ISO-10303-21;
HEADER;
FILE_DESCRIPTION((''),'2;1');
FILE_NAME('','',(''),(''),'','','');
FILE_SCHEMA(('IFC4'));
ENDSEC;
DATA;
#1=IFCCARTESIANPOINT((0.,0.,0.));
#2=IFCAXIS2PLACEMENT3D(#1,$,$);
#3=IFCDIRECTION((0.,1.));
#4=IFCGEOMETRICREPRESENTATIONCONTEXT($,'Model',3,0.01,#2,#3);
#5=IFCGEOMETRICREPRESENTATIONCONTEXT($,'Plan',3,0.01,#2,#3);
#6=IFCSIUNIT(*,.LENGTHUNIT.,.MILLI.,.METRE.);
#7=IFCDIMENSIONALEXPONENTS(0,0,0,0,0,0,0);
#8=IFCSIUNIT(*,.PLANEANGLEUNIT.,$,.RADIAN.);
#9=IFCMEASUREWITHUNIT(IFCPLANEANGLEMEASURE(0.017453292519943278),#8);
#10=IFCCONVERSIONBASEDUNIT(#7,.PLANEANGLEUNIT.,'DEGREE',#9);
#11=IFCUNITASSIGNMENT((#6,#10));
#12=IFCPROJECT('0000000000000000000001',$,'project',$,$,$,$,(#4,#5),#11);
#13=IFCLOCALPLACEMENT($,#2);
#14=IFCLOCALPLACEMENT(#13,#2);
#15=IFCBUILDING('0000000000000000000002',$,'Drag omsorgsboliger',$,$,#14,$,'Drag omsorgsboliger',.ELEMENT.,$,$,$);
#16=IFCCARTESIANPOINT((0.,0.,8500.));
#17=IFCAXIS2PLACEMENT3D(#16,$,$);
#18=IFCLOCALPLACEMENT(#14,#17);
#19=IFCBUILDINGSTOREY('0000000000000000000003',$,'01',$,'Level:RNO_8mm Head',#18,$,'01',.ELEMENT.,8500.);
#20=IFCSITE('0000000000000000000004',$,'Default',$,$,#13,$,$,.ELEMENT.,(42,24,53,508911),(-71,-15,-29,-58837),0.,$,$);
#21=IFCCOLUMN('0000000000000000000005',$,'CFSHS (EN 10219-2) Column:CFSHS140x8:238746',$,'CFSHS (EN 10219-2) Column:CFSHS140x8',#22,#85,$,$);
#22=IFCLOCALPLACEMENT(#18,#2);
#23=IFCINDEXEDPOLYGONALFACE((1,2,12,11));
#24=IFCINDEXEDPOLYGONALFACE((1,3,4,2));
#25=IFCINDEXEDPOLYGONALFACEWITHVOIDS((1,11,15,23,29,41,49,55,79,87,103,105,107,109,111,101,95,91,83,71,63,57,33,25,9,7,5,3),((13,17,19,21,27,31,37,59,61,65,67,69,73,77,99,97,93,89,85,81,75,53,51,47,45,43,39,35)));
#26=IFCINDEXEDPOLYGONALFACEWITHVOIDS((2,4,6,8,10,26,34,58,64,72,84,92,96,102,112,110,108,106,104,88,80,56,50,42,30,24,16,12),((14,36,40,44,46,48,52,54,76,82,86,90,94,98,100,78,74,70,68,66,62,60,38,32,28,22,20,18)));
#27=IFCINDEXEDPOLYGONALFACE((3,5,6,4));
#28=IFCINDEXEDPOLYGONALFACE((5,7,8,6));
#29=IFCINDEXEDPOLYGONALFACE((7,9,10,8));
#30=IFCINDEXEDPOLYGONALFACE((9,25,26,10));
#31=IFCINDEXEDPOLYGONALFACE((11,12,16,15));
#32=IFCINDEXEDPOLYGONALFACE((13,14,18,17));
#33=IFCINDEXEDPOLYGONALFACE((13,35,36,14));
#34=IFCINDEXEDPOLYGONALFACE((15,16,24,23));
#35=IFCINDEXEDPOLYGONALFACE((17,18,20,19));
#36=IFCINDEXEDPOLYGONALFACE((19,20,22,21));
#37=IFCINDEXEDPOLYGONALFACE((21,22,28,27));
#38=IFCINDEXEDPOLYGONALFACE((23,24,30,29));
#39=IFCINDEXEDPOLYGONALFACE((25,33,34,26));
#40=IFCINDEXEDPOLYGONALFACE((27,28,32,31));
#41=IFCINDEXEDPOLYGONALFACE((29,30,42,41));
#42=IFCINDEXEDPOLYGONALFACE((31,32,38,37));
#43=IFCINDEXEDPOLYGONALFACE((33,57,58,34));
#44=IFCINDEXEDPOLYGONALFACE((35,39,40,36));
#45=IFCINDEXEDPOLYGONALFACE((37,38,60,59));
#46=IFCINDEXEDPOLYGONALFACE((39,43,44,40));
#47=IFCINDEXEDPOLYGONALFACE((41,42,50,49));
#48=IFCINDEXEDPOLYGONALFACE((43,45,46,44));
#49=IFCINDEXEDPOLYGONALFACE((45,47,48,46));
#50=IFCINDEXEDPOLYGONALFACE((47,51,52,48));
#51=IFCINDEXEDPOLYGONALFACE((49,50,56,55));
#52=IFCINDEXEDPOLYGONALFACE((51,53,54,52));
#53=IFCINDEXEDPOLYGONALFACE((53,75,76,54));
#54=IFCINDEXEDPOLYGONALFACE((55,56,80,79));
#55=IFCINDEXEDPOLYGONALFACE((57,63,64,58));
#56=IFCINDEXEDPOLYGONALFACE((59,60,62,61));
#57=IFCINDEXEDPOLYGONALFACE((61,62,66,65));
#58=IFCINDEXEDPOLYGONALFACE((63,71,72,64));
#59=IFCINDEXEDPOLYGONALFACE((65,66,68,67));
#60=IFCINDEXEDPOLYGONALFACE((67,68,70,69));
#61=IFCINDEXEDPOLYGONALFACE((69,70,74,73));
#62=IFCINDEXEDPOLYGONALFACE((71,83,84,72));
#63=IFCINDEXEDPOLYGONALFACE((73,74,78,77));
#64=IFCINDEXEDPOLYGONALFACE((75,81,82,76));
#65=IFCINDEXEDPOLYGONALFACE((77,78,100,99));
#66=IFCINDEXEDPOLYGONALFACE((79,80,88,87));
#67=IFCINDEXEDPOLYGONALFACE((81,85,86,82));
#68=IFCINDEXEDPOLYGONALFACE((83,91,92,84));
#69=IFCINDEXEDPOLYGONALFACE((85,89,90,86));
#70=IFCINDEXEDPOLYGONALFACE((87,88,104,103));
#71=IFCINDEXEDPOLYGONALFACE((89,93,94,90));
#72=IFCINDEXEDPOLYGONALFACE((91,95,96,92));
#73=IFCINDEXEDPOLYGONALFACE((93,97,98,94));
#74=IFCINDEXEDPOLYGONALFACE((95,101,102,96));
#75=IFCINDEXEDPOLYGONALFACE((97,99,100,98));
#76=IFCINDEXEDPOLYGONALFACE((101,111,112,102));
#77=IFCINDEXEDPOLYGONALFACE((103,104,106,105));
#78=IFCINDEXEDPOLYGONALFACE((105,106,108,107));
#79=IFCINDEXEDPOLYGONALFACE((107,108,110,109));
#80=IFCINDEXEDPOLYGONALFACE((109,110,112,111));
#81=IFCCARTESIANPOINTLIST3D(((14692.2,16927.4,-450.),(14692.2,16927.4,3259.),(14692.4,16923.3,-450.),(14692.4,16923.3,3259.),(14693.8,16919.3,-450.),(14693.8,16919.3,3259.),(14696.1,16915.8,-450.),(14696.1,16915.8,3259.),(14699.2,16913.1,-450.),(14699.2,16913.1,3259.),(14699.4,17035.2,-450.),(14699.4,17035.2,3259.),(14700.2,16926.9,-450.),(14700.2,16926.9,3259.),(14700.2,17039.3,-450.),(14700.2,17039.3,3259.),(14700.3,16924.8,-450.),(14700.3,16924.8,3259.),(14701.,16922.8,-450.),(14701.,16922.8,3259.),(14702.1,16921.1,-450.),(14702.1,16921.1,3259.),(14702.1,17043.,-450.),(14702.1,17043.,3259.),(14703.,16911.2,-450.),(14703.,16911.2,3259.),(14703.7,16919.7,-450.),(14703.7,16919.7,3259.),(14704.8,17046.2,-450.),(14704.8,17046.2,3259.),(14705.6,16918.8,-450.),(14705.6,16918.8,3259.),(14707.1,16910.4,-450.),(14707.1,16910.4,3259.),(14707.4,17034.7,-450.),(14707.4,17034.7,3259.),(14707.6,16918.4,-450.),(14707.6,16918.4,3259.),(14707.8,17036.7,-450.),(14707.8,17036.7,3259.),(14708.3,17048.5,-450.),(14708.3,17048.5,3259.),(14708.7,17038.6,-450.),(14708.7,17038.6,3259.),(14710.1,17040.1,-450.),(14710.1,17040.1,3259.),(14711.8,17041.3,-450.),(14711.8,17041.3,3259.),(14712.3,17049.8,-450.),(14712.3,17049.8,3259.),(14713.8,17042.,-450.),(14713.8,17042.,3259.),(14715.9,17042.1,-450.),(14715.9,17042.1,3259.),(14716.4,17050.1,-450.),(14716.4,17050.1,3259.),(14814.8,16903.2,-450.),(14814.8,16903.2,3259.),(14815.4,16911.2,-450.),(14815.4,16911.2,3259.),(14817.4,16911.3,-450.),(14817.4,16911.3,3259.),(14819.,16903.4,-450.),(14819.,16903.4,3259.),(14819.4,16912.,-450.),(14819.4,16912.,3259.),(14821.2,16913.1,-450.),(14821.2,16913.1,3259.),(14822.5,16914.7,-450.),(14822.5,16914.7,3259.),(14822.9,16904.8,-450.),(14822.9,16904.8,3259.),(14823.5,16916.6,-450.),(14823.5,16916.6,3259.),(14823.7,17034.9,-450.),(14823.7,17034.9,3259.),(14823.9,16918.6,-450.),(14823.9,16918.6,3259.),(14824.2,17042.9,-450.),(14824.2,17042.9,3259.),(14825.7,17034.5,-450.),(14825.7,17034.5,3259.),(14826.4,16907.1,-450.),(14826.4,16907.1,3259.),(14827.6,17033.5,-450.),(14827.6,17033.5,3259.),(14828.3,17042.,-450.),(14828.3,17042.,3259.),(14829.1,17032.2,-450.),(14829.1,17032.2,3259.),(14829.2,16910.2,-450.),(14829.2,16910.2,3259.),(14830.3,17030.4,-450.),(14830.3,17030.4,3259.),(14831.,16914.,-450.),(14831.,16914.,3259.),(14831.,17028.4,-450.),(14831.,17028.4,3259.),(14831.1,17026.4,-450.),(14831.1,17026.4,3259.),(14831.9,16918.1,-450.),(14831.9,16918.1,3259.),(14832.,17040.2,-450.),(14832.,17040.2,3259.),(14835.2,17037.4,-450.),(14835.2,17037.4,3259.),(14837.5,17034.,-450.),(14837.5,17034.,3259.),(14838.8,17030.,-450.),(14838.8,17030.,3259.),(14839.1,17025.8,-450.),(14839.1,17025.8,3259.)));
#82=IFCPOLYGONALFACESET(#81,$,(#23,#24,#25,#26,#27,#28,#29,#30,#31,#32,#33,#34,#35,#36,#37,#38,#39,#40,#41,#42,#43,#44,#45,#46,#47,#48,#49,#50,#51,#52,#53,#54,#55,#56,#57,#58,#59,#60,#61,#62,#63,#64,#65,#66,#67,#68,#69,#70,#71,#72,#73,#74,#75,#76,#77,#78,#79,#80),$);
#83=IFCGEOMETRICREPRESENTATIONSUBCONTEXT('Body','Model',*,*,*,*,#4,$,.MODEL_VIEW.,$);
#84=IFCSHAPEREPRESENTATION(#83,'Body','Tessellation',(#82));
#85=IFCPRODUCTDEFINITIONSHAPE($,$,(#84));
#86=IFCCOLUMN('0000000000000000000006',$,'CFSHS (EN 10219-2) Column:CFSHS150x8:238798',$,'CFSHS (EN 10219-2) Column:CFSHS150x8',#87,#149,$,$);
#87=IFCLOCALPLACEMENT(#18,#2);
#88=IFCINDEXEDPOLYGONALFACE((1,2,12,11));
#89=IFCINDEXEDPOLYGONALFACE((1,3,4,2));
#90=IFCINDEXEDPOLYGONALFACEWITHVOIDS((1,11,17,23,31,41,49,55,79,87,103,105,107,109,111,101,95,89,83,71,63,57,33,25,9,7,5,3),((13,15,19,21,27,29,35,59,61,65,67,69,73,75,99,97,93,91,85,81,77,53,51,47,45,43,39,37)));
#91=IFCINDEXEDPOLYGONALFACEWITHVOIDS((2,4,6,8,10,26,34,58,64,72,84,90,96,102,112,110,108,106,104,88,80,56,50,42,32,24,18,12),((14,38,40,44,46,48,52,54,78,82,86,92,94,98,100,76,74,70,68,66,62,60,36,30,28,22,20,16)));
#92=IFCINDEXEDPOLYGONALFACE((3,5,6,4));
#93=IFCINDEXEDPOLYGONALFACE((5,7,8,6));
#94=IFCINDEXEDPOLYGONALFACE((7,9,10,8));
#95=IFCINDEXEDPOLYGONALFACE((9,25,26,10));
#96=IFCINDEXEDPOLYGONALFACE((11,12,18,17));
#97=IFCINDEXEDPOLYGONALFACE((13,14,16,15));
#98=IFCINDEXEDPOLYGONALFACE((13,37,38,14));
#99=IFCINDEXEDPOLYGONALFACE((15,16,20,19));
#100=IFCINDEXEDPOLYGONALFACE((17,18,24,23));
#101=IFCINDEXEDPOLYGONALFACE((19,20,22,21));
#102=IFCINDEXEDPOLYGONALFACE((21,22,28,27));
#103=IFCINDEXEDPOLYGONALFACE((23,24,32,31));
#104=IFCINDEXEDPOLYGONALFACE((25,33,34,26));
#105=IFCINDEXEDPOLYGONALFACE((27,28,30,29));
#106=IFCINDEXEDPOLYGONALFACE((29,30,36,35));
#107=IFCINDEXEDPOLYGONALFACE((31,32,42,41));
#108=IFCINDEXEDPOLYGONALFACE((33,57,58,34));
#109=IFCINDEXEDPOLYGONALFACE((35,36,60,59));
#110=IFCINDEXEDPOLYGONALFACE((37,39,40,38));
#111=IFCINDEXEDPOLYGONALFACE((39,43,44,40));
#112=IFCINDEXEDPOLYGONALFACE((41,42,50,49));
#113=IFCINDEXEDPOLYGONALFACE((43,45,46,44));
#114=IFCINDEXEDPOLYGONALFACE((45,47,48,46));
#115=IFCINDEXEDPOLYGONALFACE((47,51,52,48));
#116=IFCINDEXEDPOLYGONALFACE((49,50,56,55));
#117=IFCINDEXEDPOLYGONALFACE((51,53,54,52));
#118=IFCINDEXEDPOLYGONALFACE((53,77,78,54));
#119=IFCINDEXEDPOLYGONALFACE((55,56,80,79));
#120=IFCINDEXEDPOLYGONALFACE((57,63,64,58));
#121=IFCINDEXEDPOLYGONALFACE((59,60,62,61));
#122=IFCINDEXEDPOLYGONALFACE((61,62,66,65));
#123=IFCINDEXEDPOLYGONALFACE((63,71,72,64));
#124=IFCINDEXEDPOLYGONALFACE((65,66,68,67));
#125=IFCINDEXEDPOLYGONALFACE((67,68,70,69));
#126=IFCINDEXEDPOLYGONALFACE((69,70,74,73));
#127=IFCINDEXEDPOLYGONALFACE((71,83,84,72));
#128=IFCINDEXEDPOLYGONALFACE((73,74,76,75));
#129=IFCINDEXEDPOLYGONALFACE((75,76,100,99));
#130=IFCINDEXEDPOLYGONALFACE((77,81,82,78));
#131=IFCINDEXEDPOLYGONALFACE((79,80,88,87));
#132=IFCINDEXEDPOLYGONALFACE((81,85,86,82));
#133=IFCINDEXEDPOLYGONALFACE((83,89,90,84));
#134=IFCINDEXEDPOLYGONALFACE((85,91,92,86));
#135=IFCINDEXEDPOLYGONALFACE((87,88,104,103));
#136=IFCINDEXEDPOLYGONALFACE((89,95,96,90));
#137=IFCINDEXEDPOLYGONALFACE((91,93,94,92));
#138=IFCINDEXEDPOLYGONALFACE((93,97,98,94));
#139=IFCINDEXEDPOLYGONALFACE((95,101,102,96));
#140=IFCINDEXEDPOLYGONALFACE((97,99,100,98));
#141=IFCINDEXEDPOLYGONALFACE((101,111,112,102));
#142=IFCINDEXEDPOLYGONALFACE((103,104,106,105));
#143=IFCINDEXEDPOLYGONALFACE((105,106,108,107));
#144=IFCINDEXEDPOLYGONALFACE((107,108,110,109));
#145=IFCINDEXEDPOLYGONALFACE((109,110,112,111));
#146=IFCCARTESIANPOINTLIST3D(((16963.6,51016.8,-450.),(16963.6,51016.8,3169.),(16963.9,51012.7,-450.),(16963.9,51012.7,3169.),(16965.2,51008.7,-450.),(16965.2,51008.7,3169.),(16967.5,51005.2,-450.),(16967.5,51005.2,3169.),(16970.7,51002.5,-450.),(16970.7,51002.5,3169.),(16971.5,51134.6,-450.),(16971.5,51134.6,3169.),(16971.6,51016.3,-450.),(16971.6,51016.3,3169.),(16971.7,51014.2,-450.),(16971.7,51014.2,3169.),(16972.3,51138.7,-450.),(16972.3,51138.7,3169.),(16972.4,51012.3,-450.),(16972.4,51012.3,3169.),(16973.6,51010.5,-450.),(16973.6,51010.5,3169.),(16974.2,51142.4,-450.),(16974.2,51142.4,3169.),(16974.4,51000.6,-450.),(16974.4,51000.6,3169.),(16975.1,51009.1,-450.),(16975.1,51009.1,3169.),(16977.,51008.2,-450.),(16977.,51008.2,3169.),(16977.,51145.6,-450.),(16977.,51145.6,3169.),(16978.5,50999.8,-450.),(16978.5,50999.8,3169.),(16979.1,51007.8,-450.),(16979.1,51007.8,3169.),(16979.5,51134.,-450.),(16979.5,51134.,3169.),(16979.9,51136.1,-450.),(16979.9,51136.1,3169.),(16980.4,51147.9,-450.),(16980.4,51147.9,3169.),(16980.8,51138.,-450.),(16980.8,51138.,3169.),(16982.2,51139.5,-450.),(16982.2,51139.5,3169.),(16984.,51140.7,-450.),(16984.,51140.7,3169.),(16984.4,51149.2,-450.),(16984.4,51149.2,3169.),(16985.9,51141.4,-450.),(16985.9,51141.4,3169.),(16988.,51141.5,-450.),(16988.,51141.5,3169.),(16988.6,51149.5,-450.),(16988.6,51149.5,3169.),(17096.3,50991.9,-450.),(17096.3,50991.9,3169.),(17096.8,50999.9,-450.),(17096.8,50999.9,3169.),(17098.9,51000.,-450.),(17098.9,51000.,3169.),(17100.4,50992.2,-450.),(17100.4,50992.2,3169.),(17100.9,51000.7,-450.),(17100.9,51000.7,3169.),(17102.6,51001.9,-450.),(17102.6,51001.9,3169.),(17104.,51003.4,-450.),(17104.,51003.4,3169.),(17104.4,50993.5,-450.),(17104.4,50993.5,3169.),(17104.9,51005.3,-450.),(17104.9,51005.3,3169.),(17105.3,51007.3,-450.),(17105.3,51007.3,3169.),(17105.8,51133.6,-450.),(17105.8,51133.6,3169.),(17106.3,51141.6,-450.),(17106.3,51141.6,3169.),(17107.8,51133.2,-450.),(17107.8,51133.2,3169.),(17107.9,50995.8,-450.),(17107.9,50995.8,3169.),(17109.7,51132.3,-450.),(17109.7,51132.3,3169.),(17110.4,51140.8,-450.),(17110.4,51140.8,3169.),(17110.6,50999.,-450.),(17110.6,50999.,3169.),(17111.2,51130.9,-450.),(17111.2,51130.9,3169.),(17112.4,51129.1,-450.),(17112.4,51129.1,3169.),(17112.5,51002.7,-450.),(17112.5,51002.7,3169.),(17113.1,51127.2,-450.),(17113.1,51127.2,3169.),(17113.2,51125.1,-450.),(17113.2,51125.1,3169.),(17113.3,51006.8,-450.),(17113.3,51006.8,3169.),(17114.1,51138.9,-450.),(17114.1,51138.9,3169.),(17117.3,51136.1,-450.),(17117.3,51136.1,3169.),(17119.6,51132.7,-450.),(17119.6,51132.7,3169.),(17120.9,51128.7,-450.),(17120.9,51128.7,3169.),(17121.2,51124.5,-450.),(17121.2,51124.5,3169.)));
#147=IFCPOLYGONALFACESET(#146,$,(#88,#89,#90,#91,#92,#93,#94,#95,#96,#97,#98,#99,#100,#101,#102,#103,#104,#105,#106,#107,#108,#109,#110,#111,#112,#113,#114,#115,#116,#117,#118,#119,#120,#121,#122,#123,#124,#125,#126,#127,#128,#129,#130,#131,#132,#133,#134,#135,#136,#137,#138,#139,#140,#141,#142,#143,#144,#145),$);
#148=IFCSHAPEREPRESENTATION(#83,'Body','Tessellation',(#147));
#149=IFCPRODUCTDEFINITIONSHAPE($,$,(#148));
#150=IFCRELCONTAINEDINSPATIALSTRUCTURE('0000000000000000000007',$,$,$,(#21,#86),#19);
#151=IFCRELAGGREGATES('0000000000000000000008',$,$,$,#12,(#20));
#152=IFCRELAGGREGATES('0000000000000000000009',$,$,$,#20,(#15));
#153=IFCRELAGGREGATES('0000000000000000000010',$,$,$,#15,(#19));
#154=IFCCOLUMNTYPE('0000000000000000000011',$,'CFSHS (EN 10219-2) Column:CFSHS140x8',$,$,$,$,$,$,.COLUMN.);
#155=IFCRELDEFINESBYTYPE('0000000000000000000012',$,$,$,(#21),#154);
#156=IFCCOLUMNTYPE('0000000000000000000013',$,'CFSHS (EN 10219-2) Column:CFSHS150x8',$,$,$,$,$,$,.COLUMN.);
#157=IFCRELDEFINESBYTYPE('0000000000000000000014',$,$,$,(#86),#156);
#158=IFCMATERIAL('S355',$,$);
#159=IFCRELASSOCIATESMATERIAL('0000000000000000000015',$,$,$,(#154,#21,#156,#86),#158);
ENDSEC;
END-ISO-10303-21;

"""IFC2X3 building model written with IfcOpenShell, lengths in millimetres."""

from ifc_helpers import new_model, entity, si_unit, converted_unit, direction, frame, frame_2d, origin, place, context, subcontext, project, spatial, polyline, circle_curve, parameter, trimmed, segment, composite_curve, outline, extrude, source, transform, mapped, material, type_object, type_shapes, element, save


model = new_model("IFC2X3")

# Units and contexts
model_context = context("Model", 3, precision=0.01, world=origin(), true_north=direction((0.0, 1.0)))
plan_context = context("Plan", 3, precision=0.01, world=origin(), true_north=direction((0.0, 1.0)))
body_context = subcontext(model_context, "Body", "Model", "MODEL_VIEW")
ifc_project = project(units=[si_unit("LENGTHUNIT", "METRE", prefix="MILLI"), converted_unit("PLANEANGLEUNIT", "DEGREE", entity("IfcPlaneAngleMeasure", 0.017453292519943278), si_unit("PLANEANGLEUNIT", "RADIAN"), dimensions=[0, 0, 0, 0, 0, 0, 0])], contexts=[model_context, plan_context])

# Site, building, storey
site_placement = place(None, origin())
site = spatial("IfcSite", under=ifc_project, at=site_placement, Name="Default", CompositionType="ELEMENT", RefLatitude=(42, 24, 53, 508911), RefLongitude=(-71, -15, -29, -58837), RefElevation=0.0)
building_placement = place(site_placement, origin())
building = spatial("IfcBuilding", under=site, at=building_placement, Name="Drag omsorgsboliger", LongName="Drag omsorgsboliger", CompositionType="ELEMENT")
storey_placement = place(building_placement, frame((0.0, 0.0, 8500.0)))
storey = spatial("IfcBuildingStorey", under=building, at=storey_placement, Name="01", ObjectType="Level:RNO_8mm Head", LongName="01", CompositionType="ELEMENT", Elevation=8500.0)

# Columns
ifc_material = material(Name="S355")
column_type_1 = type_object("IfcColumnType", Name="CFSHS (EN 10219-2) Column:CFSHS140x8", PredefinedType="COLUMN", material=ifc_material)
shared_shape_1 = source(origin(), body_context, "Body", "SweptSolid", [
    extrude(outline(composite_curve([segment(polyline([(-54.0, -70.0), (54.0, -70.0)]), True, "CONTINUOUS"), segment(trimmed(circle_curve(frame_2d((54.0, -54.0), x_axis=(-1.0, 0.0)), 16.0), [parameter(90.0)], [parameter(180.0)], True, "PARAMETER"), True, "CONTINUOUS"), segment(polyline([(70.0, -54.0), (70.0, 54.0)]), True, "CONTINUOUS"), segment(trimmed(circle_curve(frame_2d((54.0, 54.0), x_axis=(-1.0, 0.0)), 16.0), [parameter(180.0)], [parameter(270.0)], True, "PARAMETER"), True, "CONTINUOUS"), segment(polyline([(54.0, 70.0), (-54.0, 70.0)]), True, "CONTINUOUS"), segment(trimmed(circle_curve(frame_2d((-54.0, 54.0), x_axis=(-1.0, 0.0)), 16.0), [parameter(270.0)], [parameter(360.0)], True, "PARAMETER"), True, "CONTINUOUS"), segment(polyline([(-70.0, 54.0), (-70.0, -54.0)]), True, "CONTINUOUS"), segment(trimmed(circle_curve(frame_2d((-54.0, -54.0), x_axis=(-1.0, 0.0)), 16.0), [parameter(360.0)], [parameter(90.0)], True, "PARAMETER"), True, "CONTINUOUS")], self_intersect=False), holes=[composite_curve([segment(trimmed(circle_curve(frame_2d((-54.0, -54.0), x_axis=(-1.0, 0.0)), 8.0), [parameter(360.0)], [parameter(90.0)], True, "PARAMETER"), False, "CONTINUOUS"), segment(polyline([(-62.0, -54.0), (-62.0, 54.0)]), True, "CONTINUOUS"), segment(trimmed(circle_curve(frame_2d((-54.0, 54.0), x_axis=(-1.0, 0.0)), 8.0), [parameter(270.0)], [parameter(360.0)], True, "PARAMETER"), False, "CONTINUOUS"), segment(polyline([(-54.0, 62.0), (54.0, 62.0)]), True, "CONTINUOUS"), segment(trimmed(circle_curve(frame_2d((54.0, 54.0), x_axis=(-1.0, 0.0)), 8.0), [parameter(180.0)], [parameter(270.0)], True, "PARAMETER"), False, "CONTINUOUS"), segment(polyline([(62.0, 54.0), (62.0, -54.0)]), True, "CONTINUOUS"), segment(trimmed(circle_curve(frame_2d((54.0, -54.0), x_axis=(-1.0, 0.0)), 8.0), [parameter(90.0)], [parameter(180.0)], True, "PARAMETER"), False, "CONTINUOUS"), segment(polyline([(54.0, -62.0), (-54.0, -62.0)]), True, "CONTINUOUS")], self_intersect=False)]), frame((14765.6, 16976.6, 8050.0), z_axis=(0.0, 0.0, 1.0), x_axis=(-0.997758, 0.066923, 0.0)), (0.0, 0.0, 1.0), 3709.0),
])
type_shapes(column_type_1, [shared_shape_1])
column_1_placement = place(storey_placement, frame((0.0, 0.0, -8500.0)))
element("IfcColumn", 1, at=column_1_placement, inside=storey, type_object=column_type_1, material=ifc_material, Name="CFSHS (EN 10219-2) Column:CFSHS140x8:238746", ObjectType="CFSHS (EN 10219-2) Column:CFSHS140x8", context=body_context, shape_type="MappedRepresentation", body=[
    mapped(shared_shape_1, transform((0.0, 0.0, 0.0), scale=1.0)),
])
column_type_2 = type_object("IfcColumnType", Name="CFSHS (EN 10219-2) Column:CFSHS150x8", PredefinedType="COLUMN", material=ifc_material)
shared_shape_2 = source(origin(), body_context, "Body", "SweptSolid", [
    extrude(outline(composite_curve([segment(polyline([(-59.0, -75.0), (59.0, -75.0)]), True, "CONTINUOUS"), segment(trimmed(circle_curve(frame_2d((59.0, -59.0), x_axis=(-1.0, 0.0)), 16.0), [parameter(90.0)], [parameter(180.0)], True, "PARAMETER"), True, "CONTINUOUS"), segment(polyline([(75.0, -59.0), (75.0, 59.0)]), True, "CONTINUOUS"), segment(trimmed(circle_curve(frame_2d((59.0, 59.0), x_axis=(-1.0, 0.0)), 16.0), [parameter(180.0)], [parameter(270.0)], True, "PARAMETER"), True, "CONTINUOUS"), segment(polyline([(59.0, 75.0), (-59.0, 75.0)]), True, "CONTINUOUS"), segment(trimmed(circle_curve(frame_2d((-59.0, 59.0), x_axis=(-1.0, 0.0)), 16.0), [parameter(270.0)], [parameter(360.0)], True, "PARAMETER"), True, "CONTINUOUS"), segment(polyline([(-75.0, 59.0), (-75.0, -59.0)]), True, "CONTINUOUS"), segment(trimmed(circle_curve(frame_2d((-59.0, -59.0), x_axis=(-1.0, 0.0)), 16.0), [parameter(360.0)], [parameter(90.0)], True, "PARAMETER"), True, "CONTINUOUS")], self_intersect=False), holes=[composite_curve([segment(trimmed(circle_curve(frame_2d((-59.0, -59.0), x_axis=(-1.0, 0.0)), 8.0), [parameter(360.0)], [parameter(90.0)], True, "PARAMETER"), False, "CONTINUOUS"), segment(polyline([(-67.0, -59.0), (-67.0, 59.0)]), True, "CONTINUOUS"), segment(trimmed(circle_curve(frame_2d((-59.0, 59.0), x_axis=(-1.0, 0.0)), 8.0), [parameter(270.0)], [parameter(360.0)], True, "PARAMETER"), False, "CONTINUOUS"), segment(polyline([(-59.0, 67.0), (59.0, 67.0)]), True, "CONTINUOUS"), segment(trimmed(circle_curve(frame_2d((59.0, 59.0), x_axis=(-1.0, 0.0)), 8.0), [parameter(180.0)], [parameter(270.0)], True, "PARAMETER"), False, "CONTINUOUS"), segment(polyline([(67.0, 59.0), (67.0, -59.0)]), True, "CONTINUOUS"), segment(trimmed(circle_curve(frame_2d((59.0, -59.0), x_axis=(-1.0, 0.0)), 8.0), [parameter(90.0)], [parameter(180.0)], True, "PARAMETER"), False, "CONTINUOUS"), segment(polyline([(59.0, -67.0), (-59.0, -67.0)]), True, "CONTINUOUS")], self_intersect=False)]), frame((17042.4, 51070.7, 8050.0), z_axis=(0.0, 0.0, 1.0), x_axis=(-0.997758, 0.066923, 0.0)), (0.0, 0.0, 1.0), 3619.0),
])
type_shapes(column_type_2, [shared_shape_2])
column_2_placement = place(storey_placement, frame((0.0, 0.0, -8500.0)))
element("IfcColumn", 2, at=column_2_placement, inside=storey, type_object=column_type_2, material=ifc_material, Name="CFSHS (EN 10219-2) Column:CFSHS150x8:238798", ObjectType="CFSHS (EN 10219-2) Column:CFSHS150x8", context=body_context, shape_type="MappedRepresentation", body=[
    mapped(shared_shape_2, transform((0.0, 0.0, 0.0), scale=1.0)),
])

save(model, "model.ifc")
